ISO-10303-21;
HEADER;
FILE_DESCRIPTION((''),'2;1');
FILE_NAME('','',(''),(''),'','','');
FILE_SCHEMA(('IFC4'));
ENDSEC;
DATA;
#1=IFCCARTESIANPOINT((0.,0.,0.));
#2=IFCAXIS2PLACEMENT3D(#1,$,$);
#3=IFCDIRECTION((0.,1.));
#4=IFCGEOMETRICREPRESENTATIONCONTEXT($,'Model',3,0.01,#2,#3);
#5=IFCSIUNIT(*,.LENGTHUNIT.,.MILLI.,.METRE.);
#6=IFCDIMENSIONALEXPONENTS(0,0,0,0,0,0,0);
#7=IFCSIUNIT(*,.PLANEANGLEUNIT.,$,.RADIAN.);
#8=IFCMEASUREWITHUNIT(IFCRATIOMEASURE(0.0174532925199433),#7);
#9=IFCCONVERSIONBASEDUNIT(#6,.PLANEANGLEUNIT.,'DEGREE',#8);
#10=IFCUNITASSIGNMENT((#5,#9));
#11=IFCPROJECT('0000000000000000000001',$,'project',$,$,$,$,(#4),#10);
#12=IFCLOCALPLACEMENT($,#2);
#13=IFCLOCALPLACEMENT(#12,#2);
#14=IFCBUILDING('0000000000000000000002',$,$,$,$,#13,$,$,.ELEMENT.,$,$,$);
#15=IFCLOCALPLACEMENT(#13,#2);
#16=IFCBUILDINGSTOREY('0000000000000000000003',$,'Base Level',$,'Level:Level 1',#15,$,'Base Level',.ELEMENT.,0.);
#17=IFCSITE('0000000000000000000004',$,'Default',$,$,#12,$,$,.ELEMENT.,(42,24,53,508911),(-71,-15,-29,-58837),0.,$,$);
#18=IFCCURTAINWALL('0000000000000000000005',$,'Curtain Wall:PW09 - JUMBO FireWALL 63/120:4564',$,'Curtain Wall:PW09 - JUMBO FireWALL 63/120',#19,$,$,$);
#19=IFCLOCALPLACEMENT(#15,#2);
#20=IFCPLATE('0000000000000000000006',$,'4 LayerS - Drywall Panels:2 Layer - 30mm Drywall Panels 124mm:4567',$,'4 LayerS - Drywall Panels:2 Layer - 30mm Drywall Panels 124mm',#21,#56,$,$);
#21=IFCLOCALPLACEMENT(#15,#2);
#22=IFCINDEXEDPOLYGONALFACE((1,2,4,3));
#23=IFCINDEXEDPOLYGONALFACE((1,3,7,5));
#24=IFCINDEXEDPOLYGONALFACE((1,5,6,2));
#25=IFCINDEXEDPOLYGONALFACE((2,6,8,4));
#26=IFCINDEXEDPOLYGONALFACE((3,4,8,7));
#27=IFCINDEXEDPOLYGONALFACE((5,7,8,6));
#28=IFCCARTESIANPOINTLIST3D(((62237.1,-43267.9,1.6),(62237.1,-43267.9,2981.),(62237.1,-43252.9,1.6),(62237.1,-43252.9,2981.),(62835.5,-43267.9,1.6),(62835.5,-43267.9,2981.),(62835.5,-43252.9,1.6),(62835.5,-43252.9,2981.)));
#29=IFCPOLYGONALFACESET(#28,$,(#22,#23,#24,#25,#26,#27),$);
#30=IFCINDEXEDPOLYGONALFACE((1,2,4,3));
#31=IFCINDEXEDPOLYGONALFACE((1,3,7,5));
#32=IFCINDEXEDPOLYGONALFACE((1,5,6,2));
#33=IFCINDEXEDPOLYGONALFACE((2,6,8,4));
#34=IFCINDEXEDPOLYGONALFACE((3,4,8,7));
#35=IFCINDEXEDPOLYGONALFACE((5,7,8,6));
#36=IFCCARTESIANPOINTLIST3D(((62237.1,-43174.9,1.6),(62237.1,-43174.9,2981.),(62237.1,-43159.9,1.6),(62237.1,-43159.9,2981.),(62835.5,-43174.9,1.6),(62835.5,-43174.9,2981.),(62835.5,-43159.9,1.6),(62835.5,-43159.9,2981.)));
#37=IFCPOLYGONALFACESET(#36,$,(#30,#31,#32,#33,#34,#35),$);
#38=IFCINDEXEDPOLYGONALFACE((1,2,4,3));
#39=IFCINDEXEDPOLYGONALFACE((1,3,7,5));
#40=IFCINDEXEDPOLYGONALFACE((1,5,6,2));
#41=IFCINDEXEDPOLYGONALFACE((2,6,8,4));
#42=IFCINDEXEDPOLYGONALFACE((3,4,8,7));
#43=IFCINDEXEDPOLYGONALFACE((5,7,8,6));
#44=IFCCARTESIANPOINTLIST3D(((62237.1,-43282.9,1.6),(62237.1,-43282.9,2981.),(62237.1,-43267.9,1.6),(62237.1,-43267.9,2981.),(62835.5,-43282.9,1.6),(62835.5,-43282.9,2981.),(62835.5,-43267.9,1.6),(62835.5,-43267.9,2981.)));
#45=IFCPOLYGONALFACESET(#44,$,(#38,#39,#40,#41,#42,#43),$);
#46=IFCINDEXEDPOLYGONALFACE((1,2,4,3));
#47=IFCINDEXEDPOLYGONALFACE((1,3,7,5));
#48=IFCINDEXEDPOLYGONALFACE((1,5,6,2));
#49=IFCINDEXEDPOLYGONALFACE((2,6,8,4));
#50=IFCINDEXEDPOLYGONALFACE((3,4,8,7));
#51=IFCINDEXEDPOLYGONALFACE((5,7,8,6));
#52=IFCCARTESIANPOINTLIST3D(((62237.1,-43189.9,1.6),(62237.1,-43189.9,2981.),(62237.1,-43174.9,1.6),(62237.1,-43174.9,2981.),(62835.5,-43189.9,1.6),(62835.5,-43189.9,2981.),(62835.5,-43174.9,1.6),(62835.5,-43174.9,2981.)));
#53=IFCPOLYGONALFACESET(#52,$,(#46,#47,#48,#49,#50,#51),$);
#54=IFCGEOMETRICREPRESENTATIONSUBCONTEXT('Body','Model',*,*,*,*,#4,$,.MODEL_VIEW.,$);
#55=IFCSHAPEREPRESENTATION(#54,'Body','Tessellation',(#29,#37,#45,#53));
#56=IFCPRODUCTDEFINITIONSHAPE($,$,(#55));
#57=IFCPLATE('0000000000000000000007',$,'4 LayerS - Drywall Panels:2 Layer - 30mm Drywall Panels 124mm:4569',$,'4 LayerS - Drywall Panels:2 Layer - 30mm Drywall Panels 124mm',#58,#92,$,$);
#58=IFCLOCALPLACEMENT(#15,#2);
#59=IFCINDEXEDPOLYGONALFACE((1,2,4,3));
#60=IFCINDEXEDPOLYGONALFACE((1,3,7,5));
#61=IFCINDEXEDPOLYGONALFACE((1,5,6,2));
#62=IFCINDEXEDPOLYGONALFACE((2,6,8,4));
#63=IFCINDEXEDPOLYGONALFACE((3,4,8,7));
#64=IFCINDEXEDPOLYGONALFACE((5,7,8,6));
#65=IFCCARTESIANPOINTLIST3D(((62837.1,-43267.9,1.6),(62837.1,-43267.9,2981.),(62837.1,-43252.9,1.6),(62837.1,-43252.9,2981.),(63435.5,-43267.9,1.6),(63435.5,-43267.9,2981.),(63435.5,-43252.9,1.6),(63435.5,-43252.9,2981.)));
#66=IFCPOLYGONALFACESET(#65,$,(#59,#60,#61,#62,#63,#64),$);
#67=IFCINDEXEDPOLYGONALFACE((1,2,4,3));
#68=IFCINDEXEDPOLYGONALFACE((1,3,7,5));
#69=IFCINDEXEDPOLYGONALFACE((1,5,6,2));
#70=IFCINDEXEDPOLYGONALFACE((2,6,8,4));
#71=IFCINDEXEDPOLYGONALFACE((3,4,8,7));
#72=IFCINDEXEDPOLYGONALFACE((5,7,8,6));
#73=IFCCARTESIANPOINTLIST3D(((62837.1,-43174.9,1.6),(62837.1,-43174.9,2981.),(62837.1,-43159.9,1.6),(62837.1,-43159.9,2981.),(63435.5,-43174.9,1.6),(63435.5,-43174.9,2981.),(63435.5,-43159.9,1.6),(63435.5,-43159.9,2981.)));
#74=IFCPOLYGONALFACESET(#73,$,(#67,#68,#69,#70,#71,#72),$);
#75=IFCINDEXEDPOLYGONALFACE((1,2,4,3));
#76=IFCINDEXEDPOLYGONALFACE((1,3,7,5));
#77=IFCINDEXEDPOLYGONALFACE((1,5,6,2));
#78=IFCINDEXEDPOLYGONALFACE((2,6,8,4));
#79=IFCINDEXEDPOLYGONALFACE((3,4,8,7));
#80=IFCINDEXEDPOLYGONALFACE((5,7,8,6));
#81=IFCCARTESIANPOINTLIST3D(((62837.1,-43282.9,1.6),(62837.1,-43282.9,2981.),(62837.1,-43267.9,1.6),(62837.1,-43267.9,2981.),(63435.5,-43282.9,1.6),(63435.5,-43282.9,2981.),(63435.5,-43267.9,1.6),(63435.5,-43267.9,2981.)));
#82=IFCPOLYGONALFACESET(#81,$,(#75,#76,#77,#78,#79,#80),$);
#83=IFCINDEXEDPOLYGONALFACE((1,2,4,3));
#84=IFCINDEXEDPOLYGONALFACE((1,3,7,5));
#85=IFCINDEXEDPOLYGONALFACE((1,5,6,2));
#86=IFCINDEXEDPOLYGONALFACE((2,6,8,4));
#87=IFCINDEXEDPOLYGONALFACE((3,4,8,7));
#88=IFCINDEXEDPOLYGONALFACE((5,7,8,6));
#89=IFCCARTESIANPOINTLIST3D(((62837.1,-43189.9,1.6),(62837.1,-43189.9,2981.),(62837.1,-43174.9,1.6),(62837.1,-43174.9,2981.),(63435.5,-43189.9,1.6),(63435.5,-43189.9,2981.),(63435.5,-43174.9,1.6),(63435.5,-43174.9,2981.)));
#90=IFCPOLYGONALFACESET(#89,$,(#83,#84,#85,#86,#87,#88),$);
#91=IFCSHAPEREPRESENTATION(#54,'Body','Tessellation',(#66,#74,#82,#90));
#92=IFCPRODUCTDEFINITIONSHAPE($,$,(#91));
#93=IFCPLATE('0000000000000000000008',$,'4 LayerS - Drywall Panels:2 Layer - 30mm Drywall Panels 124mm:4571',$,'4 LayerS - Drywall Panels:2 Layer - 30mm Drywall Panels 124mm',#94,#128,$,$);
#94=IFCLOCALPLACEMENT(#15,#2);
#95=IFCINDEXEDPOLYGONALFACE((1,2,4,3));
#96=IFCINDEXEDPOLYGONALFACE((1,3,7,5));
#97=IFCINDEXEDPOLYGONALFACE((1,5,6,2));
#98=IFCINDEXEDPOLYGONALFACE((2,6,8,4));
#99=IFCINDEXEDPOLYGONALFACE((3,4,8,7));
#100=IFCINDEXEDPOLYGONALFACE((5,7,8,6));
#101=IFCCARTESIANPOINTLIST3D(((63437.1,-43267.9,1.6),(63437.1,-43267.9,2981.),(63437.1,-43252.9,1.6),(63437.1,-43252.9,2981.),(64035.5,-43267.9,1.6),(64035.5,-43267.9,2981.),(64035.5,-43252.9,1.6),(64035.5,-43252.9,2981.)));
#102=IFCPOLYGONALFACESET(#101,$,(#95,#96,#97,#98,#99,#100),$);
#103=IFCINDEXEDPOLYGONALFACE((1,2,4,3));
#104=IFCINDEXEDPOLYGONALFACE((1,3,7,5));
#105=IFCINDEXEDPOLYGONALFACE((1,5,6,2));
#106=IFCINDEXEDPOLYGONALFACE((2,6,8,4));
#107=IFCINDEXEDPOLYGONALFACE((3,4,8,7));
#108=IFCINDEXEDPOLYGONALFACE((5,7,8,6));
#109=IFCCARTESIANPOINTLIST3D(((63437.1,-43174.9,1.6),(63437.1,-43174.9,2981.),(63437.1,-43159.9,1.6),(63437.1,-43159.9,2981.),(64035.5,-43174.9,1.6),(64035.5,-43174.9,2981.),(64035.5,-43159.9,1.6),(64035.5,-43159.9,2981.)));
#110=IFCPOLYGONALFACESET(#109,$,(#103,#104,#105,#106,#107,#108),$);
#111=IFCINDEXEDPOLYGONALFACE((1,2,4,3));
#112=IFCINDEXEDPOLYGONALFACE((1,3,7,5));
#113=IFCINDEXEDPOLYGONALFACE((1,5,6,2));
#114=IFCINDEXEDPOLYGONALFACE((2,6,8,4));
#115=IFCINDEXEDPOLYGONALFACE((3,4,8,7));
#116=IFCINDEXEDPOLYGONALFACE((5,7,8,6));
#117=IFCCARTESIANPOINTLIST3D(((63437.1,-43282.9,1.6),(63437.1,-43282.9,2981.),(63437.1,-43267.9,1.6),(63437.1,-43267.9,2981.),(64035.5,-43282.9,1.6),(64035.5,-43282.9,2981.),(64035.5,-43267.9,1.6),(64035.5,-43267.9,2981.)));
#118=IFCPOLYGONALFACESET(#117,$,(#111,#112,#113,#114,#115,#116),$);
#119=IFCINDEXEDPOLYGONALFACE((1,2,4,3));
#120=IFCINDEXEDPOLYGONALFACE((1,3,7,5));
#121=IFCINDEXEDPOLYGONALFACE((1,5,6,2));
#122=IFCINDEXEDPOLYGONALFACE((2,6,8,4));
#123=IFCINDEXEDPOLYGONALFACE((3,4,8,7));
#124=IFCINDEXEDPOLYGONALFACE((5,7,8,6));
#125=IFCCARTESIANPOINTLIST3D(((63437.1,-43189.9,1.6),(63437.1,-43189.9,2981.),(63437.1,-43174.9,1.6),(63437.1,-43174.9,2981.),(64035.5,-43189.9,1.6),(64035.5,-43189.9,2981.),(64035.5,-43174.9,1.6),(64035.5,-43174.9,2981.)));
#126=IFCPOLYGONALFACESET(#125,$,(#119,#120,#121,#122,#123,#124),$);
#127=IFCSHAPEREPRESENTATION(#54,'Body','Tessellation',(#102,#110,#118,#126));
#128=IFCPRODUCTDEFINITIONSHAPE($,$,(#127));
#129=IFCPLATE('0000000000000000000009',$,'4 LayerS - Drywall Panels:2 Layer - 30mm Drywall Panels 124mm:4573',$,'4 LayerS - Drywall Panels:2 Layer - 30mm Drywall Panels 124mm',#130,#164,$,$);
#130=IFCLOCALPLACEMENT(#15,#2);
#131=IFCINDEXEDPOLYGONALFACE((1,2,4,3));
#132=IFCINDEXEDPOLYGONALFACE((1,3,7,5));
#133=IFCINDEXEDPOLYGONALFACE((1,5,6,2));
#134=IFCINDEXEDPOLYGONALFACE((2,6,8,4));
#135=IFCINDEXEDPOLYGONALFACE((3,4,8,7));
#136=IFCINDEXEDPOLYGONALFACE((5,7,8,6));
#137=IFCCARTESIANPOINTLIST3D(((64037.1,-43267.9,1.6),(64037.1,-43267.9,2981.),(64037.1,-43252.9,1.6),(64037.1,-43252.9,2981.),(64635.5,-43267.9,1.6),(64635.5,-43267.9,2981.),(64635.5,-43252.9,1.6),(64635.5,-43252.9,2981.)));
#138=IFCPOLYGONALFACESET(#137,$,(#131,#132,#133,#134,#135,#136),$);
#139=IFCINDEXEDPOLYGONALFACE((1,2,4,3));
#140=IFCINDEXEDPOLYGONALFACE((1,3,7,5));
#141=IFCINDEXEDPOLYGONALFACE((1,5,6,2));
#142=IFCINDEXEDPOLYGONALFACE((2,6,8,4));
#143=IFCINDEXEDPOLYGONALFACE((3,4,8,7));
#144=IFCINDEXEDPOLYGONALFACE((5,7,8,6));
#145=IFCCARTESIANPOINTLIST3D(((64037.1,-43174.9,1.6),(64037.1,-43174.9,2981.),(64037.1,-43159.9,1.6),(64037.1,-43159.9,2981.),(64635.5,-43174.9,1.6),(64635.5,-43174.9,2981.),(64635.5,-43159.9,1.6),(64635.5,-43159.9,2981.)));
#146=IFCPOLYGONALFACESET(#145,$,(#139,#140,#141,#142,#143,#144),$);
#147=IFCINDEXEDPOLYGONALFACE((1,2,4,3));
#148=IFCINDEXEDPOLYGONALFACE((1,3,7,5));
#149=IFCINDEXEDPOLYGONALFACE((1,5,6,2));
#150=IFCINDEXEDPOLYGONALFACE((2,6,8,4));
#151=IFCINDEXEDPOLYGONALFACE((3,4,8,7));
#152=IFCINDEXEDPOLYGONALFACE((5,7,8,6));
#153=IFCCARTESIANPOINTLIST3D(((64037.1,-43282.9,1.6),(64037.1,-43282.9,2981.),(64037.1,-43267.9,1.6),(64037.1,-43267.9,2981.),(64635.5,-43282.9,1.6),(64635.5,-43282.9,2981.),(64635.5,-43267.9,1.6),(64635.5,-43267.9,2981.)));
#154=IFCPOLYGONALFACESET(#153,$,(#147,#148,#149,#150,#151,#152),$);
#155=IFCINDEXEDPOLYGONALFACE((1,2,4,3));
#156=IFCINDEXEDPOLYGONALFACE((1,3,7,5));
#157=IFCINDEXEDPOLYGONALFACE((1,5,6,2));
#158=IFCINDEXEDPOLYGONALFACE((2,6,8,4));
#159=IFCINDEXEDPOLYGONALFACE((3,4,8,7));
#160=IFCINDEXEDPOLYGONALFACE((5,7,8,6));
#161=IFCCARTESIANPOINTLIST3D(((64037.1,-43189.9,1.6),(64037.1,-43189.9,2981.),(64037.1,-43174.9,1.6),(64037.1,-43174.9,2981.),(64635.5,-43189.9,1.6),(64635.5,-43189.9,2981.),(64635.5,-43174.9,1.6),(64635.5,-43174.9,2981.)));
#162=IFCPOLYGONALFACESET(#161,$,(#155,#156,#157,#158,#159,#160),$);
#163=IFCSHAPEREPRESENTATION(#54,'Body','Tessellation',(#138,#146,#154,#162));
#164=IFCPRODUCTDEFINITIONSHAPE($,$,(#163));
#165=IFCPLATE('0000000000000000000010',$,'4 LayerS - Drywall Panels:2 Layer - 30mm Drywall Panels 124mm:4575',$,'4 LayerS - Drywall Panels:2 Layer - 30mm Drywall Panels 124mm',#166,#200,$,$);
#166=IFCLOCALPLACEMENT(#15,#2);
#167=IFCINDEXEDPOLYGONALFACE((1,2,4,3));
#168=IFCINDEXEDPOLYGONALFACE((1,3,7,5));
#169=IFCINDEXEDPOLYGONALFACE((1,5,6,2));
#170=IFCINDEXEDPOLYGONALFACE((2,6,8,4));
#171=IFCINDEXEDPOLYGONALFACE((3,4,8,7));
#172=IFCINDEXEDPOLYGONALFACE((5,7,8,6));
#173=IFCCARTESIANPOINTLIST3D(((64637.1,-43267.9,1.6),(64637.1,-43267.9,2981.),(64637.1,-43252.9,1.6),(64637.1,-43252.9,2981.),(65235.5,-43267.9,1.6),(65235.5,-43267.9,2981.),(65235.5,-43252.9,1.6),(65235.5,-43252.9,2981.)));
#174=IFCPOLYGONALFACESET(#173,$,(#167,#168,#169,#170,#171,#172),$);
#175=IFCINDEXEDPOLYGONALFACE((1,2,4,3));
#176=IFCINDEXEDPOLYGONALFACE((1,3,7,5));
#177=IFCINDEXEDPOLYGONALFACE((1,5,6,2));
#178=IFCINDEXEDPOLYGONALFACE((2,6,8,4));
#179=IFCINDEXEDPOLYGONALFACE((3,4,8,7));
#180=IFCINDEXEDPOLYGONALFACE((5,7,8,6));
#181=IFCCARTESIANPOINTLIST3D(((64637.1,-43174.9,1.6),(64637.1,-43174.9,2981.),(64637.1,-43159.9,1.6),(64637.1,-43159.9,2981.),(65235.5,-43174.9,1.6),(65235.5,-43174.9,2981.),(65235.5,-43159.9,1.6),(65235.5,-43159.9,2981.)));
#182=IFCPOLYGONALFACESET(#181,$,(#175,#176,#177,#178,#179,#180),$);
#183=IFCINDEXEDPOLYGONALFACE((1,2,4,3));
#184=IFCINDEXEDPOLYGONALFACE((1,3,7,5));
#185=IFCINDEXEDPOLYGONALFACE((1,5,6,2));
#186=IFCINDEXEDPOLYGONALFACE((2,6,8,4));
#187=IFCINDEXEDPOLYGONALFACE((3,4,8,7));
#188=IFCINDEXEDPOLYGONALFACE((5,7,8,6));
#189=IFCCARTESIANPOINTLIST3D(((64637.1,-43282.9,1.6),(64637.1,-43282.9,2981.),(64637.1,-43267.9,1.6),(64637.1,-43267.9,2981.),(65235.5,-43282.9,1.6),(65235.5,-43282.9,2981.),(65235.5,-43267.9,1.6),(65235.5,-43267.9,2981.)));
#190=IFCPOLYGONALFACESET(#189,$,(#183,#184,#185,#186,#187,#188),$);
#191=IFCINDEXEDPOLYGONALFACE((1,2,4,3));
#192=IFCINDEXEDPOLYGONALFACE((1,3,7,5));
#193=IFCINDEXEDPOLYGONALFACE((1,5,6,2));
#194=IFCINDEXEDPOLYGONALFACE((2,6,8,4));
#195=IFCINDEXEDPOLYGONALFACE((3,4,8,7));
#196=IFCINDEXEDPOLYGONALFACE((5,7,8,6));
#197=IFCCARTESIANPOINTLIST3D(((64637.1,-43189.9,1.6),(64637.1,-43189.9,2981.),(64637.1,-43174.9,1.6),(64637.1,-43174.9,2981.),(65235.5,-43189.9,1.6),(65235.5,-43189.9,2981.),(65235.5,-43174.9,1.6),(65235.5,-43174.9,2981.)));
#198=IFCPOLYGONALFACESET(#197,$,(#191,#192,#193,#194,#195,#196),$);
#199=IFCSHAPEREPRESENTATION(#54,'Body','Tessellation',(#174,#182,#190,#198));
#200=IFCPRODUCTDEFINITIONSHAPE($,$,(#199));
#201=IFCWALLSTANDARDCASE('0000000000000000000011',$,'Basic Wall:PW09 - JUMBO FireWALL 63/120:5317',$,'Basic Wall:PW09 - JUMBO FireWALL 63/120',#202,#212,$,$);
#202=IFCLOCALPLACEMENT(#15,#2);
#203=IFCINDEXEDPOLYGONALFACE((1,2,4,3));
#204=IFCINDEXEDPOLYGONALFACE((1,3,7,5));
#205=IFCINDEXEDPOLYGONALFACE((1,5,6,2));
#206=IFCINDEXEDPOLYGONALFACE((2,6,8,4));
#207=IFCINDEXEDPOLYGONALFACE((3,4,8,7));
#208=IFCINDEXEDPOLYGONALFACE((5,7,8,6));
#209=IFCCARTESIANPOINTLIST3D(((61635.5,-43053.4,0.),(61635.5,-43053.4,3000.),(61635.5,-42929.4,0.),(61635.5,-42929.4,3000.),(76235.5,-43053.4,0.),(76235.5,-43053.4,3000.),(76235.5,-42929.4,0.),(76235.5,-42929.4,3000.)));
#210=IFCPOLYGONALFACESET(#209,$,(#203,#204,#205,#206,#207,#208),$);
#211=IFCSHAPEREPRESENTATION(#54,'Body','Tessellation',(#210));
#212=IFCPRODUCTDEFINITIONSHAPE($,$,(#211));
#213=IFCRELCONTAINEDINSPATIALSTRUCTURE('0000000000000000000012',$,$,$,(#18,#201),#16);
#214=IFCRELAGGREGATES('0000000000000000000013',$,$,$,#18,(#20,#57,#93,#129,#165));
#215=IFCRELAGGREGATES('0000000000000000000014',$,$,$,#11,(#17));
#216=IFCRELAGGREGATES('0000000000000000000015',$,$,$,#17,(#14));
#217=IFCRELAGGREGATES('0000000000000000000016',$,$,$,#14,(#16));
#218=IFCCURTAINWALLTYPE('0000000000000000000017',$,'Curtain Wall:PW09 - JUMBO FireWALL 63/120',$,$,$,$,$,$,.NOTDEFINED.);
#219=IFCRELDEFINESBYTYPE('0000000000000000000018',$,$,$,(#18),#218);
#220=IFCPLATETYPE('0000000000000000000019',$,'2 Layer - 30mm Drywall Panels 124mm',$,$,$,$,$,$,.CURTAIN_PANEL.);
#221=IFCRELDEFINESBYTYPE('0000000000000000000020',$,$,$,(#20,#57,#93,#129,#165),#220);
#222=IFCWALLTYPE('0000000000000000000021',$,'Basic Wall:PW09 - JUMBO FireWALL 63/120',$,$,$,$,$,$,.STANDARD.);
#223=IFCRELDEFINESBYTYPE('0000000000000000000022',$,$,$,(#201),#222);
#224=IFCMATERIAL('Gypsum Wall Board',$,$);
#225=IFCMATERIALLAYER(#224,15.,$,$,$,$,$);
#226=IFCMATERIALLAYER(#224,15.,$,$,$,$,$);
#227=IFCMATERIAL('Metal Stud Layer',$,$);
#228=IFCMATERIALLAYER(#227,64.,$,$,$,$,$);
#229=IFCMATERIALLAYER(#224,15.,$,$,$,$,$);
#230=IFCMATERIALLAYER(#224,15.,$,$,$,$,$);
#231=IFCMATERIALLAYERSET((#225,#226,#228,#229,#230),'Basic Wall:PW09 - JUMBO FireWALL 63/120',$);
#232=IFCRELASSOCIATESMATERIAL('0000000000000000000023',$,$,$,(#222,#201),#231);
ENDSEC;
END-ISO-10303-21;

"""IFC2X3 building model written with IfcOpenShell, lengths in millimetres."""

from ifc_helpers import new_model, entity, si_unit, converted_unit, direction, frame, frame_2d, origin, origin_2d_with_axis, place, context, subcontext, project, spatial, rectangle, extrude, source, transform, mapped, material, layer, layer_set, layer_usage, type_object, type_shapes, element, aggregate, save


model = new_model("IFC2X3")

# Units and contexts
model_context = context("Model", 3, precision=0.01, world=origin(), true_north=direction((0.0, 1.0)))
body_context = subcontext(model_context, "Body", "Model", "MODEL_VIEW")
ifc_project = project(units=[si_unit("LENGTHUNIT", "METRE", prefix="MILLI"), converted_unit("PLANEANGLEUNIT", "DEGREE", entity("IfcRatioMeasure", 0.0174532925199433), si_unit("PLANEANGLEUNIT", "RADIAN"), dimensions=[0, 0, 0, 0, 0, 0, 0])], contexts=[model_context])

# Site, building, storey
site_placement = place(None, origin())
site = spatial("IfcSite", under=ifc_project, at=site_placement, Name="Default", CompositionType="ELEMENT", RefLatitude=(42, 24, 53, 508911), RefLongitude=(-71, -15, -29, -58837), RefElevation=0.0)
building_placement = place(site_placement, origin())
building = spatial("IfcBuilding", under=site, at=building_placement, CompositionType="ELEMENT")
storey_placement = place(building_placement, origin())
storey = spatial("IfcBuildingStorey", under=building, at=storey_placement, Name="Base Level", ObjectType="Level:Level 1", LongName="Base Level", CompositionType="ELEMENT", Elevation=0.0)

# Curtain wall, plates
curtain_wall_type = type_object("IfcCurtainWallType", Name="Curtain Wall:PW09 - JUMBO FireWALL 63/120", PredefinedType="NOTDEFINED")
curtain_wall_placement = place(building_placement, origin())
curtain_wall = element("IfcCurtainWall", 1, at=curtain_wall_placement, inside=storey, type_object=curtain_wall_type, Name="Curtain Wall:PW09 - JUMBO FireWALL 63/120:4564", ObjectType="Curtain Wall:PW09 - JUMBO FireWALL 63/120")
plate_type = type_object("IfcPlateType", Name="2 Layer - 30mm Drywall Panels 124mm", PredefinedType="CURTAIN_PANEL")
shared_shape_1 = source(origin(), body_context, "Body", "SweptSolid", [
    extrude(rectangle(XDim=15.0, YDim=598.4, at=origin_2d_with_axis()), frame((0.0, -39.0, 0.0), z_axis=(0.0, 0.0, 1.0), x_axis=(0.0, 1.0, 0.0)), (0.0, 0.0, 1.0), 2979.4),
    extrude(rectangle(XDim=15.0, YDim=598.4, at=origin_2d_with_axis()), frame((0.0, 54.0, 0.0), z_axis=(0.0, 0.0, 1.0), x_axis=(0.0, 1.0, 0.0)), (0.0, 0.0, 1.0), 2979.4),
    extrude(rectangle(XDim=598.4, YDim=15.0, at=frame_2d((0.0, 0.0), x_axis=(1.0, 0.0))), frame((0.0, -54.0, 0.0), z_axis=(0.0, 0.0, 1.0), x_axis=(-1.0, 0.0, 0.0)), (0.0, 0.0, 1.0), 2979.4),
    extrude(rectangle(XDim=15.0, YDim=598.4, at=frame_2d((0.0, 0.0), x_axis=(1.0, 0.0))), frame((0.0, 39.0, 0.0), z_axis=(0.0, 0.0, 1.0), x_axis=(0.0, 1.0, 0.0)), (0.0, 0.0, 1.0), 2979.4),
])
type_shapes(plate_type, [shared_shape_1])
plate_1_placement = place(curtain_wall_placement, frame((62536.3, -43221.4, 1.6)))
plate_1 = element("IfcPlate", 2, at=plate_1_placement, type_object=plate_type, Name="4 LayerS - Drywall Panels:2 Layer - 30mm Drywall Panels 124mm:4567", ObjectType="4 LayerS - Drywall Panels:2 Layer - 30mm Drywall Panels 124mm", context=body_context, shape_type="MappedRepresentation", body=[
    mapped(shared_shape_1, transform((0.0, 0.0, 0.0), scale=1.0)),
])
plate_2_placement = place(curtain_wall_placement, frame((63136.3, -43221.4, 1.6)))
plate_2 = element("IfcPlate", 3, at=plate_2_placement, type_object=plate_type, Name="4 LayerS - Drywall Panels:2 Layer - 30mm Drywall Panels 124mm:4569", ObjectType="4 LayerS - Drywall Panels:2 Layer - 30mm Drywall Panels 124mm", context=body_context, shape_type="MappedRepresentation", body=[
    mapped(shared_shape_1, transform((0.0, 0.0, 0.0), scale=1.0)),
])
plate_3_placement = place(curtain_wall_placement, frame((63736.3, -43221.4, 1.6)))
plate_3 = element("IfcPlate", 4, at=plate_3_placement, type_object=plate_type, Name="4 LayerS - Drywall Panels:2 Layer - 30mm Drywall Panels 124mm:4571", ObjectType="4 LayerS - Drywall Panels:2 Layer - 30mm Drywall Panels 124mm", context=body_context, shape_type="MappedRepresentation", body=[
    mapped(shared_shape_1, transform((0.0, 0.0, 0.0), scale=1.0)),
])
plate_4_placement = place(curtain_wall_placement, frame((64336.3, -43221.4, 1.6)))
plate_4 = element("IfcPlate", 5, at=plate_4_placement, type_object=plate_type, Name="4 LayerS - Drywall Panels:2 Layer - 30mm Drywall Panels 124mm:4573", ObjectType="4 LayerS - Drywall Panels:2 Layer - 30mm Drywall Panels 124mm", context=body_context, shape_type="MappedRepresentation", body=[
    mapped(shared_shape_1, transform((0.0, 0.0, 0.0), scale=1.0)),
])
plate_5_placement = place(curtain_wall_placement, frame((64936.3, -43221.4, 1.6)))
plate_5 = element("IfcPlate", 6, at=plate_5_placement, type_object=plate_type, Name="4 LayerS - Drywall Panels:2 Layer - 30mm Drywall Panels 124mm:4575", ObjectType="4 LayerS - Drywall Panels:2 Layer - 30mm Drywall Panels 124mm", context=body_context, shape_type="MappedRepresentation", body=[
    mapped(shared_shape_1, transform((0.0, 0.0, 0.0), scale=1.0)),
])
aggregate(curtain_wall, [plate_1, plate_2, plate_3, plate_4, plate_5])

# Wall
ifc_material_1 = material(Name="Gypsum Wall Board")
ifc_layer_1 = layer(ifc_material_1, 15.0)
ifc_layer_2 = layer(ifc_material_1, 15.0)
ifc_material_2 = material(Name="Metal Stud Layer")
ifc_layer_3 = layer(ifc_material_2, 64.0)
ifc_layer_4 = layer(ifc_material_1, 15.0)
ifc_layer_5 = layer(ifc_material_1, 15.0)
ifc_layer_set = layer_set([ifc_layer_1, ifc_layer_2, ifc_layer_3, ifc_layer_4, ifc_layer_5], Name="Basic Wall:PW09 - JUMBO FireWALL 63/120")
ifc_layer_usage = layer_usage(ifc_layer_set, "AXIS2", "NEGATIVE", 62.0)
wall_type = type_object("IfcWallType", Name="Basic Wall:PW09 - JUMBO FireWALL 63/120", PredefinedType="STANDARD", material=ifc_layer_set)
wall_placement = place(building_placement, frame((61635.5, -42991.4, 0.0)))
element("IfcWallStandardCase", 7, at=wall_placement, inside=storey, type_object=wall_type, material=ifc_layer_usage, Name="Basic Wall:PW09 - JUMBO FireWALL 63/120:5317", ObjectType="Basic Wall:PW09 - JUMBO FireWALL 63/120", context=body_context, shape_type="SweptSolid", body=[
    extrude(rectangle(XDim=14600.0, YDim=124.0, at=frame_2d((7300.0, 0.0), x_axis=(-1.0, 0.0))), origin(), (0.0, 0.0, 1.0), 3000.0),
])

save(model, "model.ifc")
